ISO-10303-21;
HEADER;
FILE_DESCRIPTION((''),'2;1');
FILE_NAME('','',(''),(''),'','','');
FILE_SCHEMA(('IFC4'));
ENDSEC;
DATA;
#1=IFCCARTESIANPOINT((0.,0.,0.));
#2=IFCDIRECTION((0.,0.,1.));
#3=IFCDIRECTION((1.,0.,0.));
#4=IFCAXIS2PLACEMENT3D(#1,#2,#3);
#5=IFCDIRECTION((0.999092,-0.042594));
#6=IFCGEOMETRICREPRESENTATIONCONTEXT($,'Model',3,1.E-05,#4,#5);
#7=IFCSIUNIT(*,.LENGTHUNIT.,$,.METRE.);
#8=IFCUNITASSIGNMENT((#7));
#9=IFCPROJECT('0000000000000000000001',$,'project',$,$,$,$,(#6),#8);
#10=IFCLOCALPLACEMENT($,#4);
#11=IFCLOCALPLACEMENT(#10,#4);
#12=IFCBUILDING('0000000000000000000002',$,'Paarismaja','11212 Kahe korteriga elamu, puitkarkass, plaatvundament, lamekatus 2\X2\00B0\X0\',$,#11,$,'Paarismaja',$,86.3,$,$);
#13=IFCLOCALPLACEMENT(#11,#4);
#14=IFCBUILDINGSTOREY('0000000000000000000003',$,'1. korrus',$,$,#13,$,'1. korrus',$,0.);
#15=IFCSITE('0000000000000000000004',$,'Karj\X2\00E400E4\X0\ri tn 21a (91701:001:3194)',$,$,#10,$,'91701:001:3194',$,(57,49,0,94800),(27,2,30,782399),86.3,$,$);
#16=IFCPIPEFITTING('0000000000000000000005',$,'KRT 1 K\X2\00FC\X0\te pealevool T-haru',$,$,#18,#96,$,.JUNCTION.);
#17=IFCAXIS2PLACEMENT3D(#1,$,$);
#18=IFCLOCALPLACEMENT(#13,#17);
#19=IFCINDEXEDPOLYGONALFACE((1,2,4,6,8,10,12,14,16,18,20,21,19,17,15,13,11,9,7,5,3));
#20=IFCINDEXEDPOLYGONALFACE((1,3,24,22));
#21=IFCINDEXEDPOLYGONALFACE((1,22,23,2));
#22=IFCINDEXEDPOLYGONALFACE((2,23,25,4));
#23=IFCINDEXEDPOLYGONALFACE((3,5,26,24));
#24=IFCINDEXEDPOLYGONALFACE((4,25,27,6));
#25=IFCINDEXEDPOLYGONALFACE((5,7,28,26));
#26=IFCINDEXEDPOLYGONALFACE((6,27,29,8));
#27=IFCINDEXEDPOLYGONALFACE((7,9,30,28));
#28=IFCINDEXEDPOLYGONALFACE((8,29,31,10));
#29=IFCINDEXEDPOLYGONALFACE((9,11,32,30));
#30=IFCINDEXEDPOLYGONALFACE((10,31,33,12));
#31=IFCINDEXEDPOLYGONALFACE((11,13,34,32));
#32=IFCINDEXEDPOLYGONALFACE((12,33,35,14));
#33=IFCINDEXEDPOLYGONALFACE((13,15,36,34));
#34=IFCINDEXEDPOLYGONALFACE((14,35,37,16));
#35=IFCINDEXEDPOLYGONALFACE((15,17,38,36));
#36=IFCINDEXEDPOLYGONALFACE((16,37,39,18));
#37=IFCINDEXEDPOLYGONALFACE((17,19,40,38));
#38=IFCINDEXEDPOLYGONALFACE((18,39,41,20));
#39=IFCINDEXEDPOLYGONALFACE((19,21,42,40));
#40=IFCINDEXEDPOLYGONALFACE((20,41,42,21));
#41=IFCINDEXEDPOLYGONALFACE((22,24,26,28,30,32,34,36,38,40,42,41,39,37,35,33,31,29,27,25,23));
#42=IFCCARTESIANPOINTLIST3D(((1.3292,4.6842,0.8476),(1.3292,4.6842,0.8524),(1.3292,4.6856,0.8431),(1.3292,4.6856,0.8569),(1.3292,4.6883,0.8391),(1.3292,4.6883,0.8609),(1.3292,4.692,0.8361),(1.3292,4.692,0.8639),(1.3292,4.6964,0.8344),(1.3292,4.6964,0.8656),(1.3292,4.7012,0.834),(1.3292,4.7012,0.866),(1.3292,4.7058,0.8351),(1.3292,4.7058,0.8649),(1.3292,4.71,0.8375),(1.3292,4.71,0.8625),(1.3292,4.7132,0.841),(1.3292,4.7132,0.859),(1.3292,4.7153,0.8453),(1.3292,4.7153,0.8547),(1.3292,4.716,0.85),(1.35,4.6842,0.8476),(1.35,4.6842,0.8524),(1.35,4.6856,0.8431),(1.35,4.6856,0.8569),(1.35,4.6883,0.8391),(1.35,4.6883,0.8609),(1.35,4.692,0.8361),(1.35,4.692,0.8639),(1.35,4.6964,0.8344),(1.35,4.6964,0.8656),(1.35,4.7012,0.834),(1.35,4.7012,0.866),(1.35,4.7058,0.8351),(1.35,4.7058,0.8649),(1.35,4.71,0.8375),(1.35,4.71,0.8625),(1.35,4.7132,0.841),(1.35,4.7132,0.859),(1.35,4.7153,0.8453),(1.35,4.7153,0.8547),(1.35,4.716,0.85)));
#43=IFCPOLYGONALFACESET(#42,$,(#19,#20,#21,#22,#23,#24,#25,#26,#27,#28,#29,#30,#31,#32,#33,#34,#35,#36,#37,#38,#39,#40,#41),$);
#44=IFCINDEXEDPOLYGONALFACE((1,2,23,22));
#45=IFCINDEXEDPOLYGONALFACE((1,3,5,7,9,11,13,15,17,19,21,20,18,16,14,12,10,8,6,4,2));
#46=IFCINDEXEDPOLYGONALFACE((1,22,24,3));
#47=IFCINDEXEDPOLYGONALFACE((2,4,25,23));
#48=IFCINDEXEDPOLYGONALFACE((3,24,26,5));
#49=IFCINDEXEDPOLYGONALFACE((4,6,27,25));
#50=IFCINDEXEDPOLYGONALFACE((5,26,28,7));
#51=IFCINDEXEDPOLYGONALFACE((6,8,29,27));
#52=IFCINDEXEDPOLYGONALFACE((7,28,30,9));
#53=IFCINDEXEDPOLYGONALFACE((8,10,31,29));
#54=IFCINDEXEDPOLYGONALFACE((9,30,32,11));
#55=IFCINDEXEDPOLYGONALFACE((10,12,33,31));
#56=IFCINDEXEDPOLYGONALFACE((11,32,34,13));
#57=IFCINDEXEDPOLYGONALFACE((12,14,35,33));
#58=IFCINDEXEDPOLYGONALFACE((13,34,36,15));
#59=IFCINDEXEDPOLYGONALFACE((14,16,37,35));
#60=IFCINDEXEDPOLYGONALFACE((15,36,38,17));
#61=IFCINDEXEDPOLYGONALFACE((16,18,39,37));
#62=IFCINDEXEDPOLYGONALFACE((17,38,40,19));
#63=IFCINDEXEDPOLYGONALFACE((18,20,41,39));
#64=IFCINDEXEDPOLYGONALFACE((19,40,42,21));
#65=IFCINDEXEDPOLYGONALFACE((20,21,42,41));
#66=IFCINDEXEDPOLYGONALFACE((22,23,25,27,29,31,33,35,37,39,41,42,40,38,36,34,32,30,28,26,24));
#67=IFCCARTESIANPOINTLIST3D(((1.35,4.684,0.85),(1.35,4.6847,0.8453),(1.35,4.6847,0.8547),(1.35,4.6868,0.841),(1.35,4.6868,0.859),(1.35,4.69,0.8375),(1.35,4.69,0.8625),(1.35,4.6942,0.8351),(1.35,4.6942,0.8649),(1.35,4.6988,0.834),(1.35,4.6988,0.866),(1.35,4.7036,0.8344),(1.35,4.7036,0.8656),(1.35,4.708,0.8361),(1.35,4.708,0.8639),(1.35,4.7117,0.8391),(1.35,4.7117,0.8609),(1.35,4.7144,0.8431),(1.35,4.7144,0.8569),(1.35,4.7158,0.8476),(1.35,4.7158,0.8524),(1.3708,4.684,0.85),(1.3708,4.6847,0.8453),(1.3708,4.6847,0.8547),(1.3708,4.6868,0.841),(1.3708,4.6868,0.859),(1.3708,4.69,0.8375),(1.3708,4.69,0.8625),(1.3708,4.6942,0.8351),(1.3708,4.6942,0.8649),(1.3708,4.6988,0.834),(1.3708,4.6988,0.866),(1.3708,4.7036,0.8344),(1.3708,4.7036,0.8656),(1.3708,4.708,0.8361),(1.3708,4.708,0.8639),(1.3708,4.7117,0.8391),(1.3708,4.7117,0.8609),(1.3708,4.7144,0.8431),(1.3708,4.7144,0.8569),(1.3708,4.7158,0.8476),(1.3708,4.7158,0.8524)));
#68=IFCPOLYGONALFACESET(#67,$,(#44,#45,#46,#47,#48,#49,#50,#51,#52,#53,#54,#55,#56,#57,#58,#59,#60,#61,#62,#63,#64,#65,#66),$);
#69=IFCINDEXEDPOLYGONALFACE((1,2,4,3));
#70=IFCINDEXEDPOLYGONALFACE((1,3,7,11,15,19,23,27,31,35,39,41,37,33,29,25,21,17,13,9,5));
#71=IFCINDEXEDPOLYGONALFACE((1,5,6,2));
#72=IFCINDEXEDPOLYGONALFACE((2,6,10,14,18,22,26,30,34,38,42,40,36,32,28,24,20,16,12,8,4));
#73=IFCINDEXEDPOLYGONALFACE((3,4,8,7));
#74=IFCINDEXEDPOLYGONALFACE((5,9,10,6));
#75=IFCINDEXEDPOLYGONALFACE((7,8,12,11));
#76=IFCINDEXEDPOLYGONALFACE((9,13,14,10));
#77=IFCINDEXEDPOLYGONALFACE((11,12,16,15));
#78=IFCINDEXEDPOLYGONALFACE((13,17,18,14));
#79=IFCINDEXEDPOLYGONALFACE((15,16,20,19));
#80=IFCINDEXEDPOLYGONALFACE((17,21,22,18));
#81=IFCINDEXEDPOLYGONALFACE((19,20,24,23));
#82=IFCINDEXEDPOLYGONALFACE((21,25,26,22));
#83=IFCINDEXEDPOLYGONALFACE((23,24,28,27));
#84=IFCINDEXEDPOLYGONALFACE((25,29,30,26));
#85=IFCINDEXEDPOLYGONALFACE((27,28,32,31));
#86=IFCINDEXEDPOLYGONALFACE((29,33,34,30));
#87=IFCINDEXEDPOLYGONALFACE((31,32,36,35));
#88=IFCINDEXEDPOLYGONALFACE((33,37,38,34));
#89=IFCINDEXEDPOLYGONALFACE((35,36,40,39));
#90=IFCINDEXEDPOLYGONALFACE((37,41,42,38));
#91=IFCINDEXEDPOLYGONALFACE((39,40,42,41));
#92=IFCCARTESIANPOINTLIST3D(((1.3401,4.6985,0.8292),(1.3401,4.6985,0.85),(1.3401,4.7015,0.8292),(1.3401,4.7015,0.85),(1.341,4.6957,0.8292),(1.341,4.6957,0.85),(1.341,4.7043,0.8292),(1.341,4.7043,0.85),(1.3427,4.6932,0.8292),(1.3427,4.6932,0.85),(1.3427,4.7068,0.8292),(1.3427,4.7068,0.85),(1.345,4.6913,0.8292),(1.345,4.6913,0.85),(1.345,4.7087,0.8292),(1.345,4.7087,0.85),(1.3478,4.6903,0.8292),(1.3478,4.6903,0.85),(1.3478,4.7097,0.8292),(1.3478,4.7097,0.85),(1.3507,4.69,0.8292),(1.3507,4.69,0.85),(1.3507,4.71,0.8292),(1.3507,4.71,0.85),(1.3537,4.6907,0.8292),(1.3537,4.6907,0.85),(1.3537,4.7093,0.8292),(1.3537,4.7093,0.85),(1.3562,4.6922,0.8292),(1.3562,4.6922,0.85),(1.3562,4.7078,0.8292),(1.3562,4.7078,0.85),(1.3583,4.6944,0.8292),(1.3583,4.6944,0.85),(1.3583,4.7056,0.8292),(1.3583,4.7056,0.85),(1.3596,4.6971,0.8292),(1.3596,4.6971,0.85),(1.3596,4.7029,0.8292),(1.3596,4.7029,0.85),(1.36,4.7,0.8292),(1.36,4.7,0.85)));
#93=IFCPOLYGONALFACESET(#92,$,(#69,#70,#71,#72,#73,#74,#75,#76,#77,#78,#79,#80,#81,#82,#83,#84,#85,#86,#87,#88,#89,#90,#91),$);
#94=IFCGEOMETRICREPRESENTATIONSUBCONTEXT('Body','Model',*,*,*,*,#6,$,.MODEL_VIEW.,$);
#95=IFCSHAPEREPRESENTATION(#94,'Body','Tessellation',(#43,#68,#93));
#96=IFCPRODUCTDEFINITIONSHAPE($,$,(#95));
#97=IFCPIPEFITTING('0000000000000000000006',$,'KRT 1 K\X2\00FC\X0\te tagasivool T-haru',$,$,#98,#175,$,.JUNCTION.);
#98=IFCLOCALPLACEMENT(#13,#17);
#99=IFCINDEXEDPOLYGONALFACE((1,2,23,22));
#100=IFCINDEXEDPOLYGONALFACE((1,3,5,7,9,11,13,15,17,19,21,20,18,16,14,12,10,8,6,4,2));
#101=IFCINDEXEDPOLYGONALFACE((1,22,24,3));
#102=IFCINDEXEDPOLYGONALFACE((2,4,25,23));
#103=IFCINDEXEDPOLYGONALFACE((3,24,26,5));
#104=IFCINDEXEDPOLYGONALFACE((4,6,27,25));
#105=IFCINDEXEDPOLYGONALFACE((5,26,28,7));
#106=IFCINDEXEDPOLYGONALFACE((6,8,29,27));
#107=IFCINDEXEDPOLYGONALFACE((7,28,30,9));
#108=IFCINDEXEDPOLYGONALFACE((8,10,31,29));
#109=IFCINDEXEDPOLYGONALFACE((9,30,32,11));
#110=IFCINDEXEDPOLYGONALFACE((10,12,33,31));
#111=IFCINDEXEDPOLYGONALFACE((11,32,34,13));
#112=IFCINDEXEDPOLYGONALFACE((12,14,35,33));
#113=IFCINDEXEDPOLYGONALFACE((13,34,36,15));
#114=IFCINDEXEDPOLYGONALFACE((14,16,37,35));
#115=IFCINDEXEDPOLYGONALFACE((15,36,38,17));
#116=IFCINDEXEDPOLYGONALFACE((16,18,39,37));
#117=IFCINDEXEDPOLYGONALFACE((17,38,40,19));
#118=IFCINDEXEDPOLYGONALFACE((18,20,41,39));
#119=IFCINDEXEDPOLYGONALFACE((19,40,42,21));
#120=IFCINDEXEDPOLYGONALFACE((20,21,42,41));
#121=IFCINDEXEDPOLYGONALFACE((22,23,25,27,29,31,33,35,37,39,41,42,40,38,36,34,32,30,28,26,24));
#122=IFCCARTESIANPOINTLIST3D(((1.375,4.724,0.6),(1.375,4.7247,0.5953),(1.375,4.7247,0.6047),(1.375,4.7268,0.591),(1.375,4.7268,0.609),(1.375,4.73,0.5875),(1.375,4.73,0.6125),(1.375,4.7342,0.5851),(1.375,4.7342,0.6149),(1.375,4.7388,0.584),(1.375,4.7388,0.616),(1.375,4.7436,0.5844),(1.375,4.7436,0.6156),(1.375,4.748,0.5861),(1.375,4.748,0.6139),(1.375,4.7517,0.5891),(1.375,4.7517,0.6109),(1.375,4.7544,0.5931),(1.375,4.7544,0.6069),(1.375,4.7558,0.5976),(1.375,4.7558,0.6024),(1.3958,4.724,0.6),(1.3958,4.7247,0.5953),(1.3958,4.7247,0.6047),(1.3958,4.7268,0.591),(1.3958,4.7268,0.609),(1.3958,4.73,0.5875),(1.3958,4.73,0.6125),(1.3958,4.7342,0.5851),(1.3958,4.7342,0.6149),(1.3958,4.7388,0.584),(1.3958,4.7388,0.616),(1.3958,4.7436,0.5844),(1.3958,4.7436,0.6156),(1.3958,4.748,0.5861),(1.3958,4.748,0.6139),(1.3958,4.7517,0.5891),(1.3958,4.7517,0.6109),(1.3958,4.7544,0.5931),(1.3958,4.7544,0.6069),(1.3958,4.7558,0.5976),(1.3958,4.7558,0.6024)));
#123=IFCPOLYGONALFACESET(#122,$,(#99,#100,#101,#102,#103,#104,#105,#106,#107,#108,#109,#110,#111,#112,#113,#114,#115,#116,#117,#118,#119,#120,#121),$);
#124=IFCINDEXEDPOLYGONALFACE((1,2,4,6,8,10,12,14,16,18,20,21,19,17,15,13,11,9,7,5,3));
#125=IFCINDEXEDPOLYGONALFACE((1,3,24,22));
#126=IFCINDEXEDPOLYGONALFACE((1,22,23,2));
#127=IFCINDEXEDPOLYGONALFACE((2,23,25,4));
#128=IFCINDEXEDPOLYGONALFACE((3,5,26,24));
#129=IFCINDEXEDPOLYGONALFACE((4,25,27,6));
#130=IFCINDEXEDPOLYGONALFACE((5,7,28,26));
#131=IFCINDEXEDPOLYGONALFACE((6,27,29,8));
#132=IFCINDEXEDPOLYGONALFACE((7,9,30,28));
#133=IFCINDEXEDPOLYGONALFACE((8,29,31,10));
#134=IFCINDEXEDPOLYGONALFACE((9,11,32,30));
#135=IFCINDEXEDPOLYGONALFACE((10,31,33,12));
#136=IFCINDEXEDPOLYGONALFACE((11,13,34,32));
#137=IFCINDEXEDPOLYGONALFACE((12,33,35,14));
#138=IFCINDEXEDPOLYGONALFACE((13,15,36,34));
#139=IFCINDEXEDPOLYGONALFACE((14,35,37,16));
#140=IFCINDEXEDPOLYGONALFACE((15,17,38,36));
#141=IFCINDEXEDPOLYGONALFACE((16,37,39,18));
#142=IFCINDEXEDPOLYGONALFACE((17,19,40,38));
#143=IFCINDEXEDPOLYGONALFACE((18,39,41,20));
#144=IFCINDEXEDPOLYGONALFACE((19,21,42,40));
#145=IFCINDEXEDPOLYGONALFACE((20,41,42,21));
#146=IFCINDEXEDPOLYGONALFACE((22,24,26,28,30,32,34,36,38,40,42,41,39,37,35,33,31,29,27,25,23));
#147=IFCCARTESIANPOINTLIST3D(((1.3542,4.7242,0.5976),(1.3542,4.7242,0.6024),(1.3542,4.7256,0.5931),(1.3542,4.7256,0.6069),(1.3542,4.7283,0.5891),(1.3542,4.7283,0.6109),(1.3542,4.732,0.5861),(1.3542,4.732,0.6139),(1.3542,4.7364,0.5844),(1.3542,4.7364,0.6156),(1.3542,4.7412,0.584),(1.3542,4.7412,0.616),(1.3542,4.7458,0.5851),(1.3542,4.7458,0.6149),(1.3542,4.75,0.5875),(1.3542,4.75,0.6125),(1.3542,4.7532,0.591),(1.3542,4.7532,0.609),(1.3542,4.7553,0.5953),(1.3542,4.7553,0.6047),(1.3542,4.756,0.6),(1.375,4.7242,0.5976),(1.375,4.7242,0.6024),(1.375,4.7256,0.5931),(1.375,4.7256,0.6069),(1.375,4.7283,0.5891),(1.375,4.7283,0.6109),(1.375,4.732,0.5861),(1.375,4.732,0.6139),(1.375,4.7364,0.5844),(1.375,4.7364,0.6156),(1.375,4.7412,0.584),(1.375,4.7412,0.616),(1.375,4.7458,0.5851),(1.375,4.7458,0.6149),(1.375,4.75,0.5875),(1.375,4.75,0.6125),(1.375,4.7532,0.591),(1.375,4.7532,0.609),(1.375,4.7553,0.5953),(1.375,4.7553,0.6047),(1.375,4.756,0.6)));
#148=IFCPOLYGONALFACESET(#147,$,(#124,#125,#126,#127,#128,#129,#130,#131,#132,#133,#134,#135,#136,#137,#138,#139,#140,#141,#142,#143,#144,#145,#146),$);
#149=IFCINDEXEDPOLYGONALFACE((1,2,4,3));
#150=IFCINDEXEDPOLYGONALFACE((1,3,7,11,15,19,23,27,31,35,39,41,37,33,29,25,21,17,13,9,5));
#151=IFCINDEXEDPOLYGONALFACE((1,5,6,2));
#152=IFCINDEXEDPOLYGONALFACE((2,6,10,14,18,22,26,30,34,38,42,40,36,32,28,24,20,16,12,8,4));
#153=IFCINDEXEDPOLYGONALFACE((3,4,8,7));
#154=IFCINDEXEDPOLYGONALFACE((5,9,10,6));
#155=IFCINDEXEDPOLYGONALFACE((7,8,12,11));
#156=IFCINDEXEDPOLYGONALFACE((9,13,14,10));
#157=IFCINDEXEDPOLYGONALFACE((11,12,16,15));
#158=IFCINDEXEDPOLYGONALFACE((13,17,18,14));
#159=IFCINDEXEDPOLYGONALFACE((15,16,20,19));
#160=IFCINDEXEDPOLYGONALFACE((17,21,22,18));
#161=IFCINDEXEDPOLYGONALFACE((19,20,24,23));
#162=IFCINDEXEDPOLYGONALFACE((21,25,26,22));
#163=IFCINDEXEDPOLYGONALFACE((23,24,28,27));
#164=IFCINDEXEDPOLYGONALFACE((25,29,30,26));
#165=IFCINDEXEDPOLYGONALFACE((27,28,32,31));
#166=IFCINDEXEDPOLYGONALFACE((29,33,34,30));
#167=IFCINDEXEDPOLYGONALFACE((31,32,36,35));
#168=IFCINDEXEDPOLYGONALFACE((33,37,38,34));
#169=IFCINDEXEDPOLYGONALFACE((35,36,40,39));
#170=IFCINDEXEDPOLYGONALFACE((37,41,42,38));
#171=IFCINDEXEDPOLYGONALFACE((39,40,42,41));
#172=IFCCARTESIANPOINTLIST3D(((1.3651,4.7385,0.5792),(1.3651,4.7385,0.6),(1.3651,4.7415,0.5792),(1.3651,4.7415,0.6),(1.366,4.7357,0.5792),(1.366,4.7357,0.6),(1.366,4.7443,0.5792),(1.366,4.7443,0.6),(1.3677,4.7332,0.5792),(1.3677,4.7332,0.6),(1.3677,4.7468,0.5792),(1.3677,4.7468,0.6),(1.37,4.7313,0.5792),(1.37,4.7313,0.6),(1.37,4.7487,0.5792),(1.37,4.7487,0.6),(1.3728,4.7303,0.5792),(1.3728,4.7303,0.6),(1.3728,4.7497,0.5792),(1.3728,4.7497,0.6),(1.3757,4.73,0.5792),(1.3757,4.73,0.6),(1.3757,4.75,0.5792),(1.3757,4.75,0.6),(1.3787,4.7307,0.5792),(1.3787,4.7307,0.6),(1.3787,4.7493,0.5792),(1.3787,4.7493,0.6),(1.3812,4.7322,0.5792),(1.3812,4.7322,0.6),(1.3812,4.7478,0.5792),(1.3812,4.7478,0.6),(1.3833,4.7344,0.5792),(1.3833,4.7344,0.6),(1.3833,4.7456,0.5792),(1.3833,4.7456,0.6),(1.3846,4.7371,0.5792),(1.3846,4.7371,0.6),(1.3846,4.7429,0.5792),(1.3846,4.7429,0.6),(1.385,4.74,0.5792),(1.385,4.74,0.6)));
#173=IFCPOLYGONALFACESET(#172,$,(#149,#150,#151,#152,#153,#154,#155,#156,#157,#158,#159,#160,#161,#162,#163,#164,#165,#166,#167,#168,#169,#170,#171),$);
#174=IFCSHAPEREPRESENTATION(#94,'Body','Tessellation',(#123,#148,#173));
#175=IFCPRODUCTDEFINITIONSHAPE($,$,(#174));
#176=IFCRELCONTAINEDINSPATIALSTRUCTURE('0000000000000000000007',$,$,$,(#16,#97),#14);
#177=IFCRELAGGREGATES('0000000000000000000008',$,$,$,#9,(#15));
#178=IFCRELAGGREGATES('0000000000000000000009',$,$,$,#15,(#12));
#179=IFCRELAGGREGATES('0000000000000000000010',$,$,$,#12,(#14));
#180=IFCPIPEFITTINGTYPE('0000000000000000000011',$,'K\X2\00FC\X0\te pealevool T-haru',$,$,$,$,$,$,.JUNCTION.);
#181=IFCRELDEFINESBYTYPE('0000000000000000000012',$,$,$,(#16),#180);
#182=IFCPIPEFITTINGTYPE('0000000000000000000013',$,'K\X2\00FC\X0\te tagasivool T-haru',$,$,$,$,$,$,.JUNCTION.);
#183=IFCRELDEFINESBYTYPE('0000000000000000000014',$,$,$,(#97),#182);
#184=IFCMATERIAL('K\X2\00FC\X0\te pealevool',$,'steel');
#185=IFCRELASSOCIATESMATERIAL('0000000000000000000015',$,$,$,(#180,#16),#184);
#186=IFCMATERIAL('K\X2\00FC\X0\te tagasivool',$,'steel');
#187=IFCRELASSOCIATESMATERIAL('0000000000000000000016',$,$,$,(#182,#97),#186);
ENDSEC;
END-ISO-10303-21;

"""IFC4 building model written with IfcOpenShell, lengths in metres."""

from ifc_helpers import new_model, si_unit, direction, frame, origin_with_axes, place, context, subcontext, project, spatial, circle, extrude, material, type_object, element, save


model = new_model("IFC4")

# Units and contexts
model_context = context("Model", 3, precision=1e-05, world=origin_with_axes(), true_north=direction((0.999092, -0.042594)))
body_context = subcontext(model_context, "Body", "Model", "MODEL_VIEW")
ifc_project = project(units=[si_unit("LENGTHUNIT", "METRE")], contexts=[model_context])

# Site, building, storey
site_placement = place(None, origin_with_axes())
site = spatial("IfcSite", under=ifc_project, at=site_placement, Name="Karjääri tn 21a (91701:001:3194)", LongName="91701:001:3194", RefLatitude=(57, 49, 0, 94800), RefLongitude=(27, 2, 30, 782399), RefElevation=86.3)
building_placement = place(site_placement, origin_with_axes())
building = spatial("IfcBuilding", under=site, at=building_placement, Name="Paarismaja", Description="11212 Kahe korteriga elamu, puitkarkass, plaatvundament, lamekatus 2°", LongName="Paarismaja", ElevationOfRefHeight=86.3)
storey_placement = place(building_placement, origin_with_axes())
storey = spatial("IfcBuildingStorey", under=building, at=storey_placement, Name="1. korrus", LongName="1. korrus", Elevation=0.0)

# Pipe fittings
ifc_material_1 = material(Name="Küte pealevool", Category="steel")
pipe_fitting_type_1 = type_object("IfcPipeFittingType", Name="Küte pealevool T-haru", PredefinedType="JUNCTION", material=ifc_material_1)
for number, where, z_axis, x_axis, name in (
    (1, (1.35, 4.7, 0.85), (0.0, 0.0, 1.0), (1.0, 0.0, 0.0), "KRT 1 Küte pealevool T-haru"),
):
    element("IfcPipeFitting", number, at=place(storey_placement, frame(where, z_axis=z_axis, x_axis=x_axis)), inside=storey, type_object=pipe_fitting_type_1, material=ifc_material_1, Name=name, PredefinedType="JUNCTION", context=body_context, shape_type="SweptSolid", body=[
        extrude(circle(Radius=0.016), frame((0.0, 0.0, 0.0), z_axis=(-1.0, 0.0, 0.0), x_axis=(0.0, 1.0, 0.0)), (0.0, 0.0, 1.0), 0.0208),
        extrude(circle(Radius=0.016), frame((0.0, 0.0, 0.0), z_axis=(1.0, 0.0, 0.0), x_axis=(0.0, -1.0, 0.0)), (0.0, 0.0, 1.0), 0.0208),
        extrude(circle(Radius=0.01), frame((0.0, 0.0, 0.0), z_axis=(0.0, 0.0, -1.0), x_axis=(1.0, 0.0, 0.0)), (0.0, 0.0, 1.0), 0.0208),
    ])
ifc_material_2 = material(Name="Küte tagasivool", Category="steel")
pipe_fitting_type_2 = type_object("IfcPipeFittingType", Name="Küte tagasivool T-haru", PredefinedType="JUNCTION", material=ifc_material_2)
for number, where, z_axis, x_axis, name in (
    (2, (1.375, 4.74, 0.6), (0.0, 0.0, 1.0), (1.0, 0.0, 0.0), "KRT 1 Küte tagasivool T-haru"),
):
    element("IfcPipeFitting", number, at=place(storey_placement, frame(where, z_axis=z_axis, x_axis=x_axis)), inside=storey, type_object=pipe_fitting_type_2, material=ifc_material_2, Name=name, PredefinedType="JUNCTION", context=body_context, shape_type="SweptSolid", body=[
        extrude(circle(Radius=0.016), frame((0.0, 0.0, 0.0), z_axis=(1.0, 0.0, 0.0), x_axis=(0.0, -1.0, 0.0)), (0.0, 0.0, 1.0), 0.0208),
        extrude(circle(Radius=0.016), frame((0.0, 0.0, 0.0), z_axis=(-1.0, 0.0, 0.0), x_axis=(0.0, 1.0, 0.0)), (0.0, 0.0, 1.0), 0.0208),
        extrude(circle(Radius=0.01), frame((0.0, 0.0, 0.0), z_axis=(0.0, 0.0, -1.0), x_axis=(1.0, 0.0, 0.0)), (0.0, 0.0, 1.0), 0.0208),
    ])

save(model, "model.ifc")
